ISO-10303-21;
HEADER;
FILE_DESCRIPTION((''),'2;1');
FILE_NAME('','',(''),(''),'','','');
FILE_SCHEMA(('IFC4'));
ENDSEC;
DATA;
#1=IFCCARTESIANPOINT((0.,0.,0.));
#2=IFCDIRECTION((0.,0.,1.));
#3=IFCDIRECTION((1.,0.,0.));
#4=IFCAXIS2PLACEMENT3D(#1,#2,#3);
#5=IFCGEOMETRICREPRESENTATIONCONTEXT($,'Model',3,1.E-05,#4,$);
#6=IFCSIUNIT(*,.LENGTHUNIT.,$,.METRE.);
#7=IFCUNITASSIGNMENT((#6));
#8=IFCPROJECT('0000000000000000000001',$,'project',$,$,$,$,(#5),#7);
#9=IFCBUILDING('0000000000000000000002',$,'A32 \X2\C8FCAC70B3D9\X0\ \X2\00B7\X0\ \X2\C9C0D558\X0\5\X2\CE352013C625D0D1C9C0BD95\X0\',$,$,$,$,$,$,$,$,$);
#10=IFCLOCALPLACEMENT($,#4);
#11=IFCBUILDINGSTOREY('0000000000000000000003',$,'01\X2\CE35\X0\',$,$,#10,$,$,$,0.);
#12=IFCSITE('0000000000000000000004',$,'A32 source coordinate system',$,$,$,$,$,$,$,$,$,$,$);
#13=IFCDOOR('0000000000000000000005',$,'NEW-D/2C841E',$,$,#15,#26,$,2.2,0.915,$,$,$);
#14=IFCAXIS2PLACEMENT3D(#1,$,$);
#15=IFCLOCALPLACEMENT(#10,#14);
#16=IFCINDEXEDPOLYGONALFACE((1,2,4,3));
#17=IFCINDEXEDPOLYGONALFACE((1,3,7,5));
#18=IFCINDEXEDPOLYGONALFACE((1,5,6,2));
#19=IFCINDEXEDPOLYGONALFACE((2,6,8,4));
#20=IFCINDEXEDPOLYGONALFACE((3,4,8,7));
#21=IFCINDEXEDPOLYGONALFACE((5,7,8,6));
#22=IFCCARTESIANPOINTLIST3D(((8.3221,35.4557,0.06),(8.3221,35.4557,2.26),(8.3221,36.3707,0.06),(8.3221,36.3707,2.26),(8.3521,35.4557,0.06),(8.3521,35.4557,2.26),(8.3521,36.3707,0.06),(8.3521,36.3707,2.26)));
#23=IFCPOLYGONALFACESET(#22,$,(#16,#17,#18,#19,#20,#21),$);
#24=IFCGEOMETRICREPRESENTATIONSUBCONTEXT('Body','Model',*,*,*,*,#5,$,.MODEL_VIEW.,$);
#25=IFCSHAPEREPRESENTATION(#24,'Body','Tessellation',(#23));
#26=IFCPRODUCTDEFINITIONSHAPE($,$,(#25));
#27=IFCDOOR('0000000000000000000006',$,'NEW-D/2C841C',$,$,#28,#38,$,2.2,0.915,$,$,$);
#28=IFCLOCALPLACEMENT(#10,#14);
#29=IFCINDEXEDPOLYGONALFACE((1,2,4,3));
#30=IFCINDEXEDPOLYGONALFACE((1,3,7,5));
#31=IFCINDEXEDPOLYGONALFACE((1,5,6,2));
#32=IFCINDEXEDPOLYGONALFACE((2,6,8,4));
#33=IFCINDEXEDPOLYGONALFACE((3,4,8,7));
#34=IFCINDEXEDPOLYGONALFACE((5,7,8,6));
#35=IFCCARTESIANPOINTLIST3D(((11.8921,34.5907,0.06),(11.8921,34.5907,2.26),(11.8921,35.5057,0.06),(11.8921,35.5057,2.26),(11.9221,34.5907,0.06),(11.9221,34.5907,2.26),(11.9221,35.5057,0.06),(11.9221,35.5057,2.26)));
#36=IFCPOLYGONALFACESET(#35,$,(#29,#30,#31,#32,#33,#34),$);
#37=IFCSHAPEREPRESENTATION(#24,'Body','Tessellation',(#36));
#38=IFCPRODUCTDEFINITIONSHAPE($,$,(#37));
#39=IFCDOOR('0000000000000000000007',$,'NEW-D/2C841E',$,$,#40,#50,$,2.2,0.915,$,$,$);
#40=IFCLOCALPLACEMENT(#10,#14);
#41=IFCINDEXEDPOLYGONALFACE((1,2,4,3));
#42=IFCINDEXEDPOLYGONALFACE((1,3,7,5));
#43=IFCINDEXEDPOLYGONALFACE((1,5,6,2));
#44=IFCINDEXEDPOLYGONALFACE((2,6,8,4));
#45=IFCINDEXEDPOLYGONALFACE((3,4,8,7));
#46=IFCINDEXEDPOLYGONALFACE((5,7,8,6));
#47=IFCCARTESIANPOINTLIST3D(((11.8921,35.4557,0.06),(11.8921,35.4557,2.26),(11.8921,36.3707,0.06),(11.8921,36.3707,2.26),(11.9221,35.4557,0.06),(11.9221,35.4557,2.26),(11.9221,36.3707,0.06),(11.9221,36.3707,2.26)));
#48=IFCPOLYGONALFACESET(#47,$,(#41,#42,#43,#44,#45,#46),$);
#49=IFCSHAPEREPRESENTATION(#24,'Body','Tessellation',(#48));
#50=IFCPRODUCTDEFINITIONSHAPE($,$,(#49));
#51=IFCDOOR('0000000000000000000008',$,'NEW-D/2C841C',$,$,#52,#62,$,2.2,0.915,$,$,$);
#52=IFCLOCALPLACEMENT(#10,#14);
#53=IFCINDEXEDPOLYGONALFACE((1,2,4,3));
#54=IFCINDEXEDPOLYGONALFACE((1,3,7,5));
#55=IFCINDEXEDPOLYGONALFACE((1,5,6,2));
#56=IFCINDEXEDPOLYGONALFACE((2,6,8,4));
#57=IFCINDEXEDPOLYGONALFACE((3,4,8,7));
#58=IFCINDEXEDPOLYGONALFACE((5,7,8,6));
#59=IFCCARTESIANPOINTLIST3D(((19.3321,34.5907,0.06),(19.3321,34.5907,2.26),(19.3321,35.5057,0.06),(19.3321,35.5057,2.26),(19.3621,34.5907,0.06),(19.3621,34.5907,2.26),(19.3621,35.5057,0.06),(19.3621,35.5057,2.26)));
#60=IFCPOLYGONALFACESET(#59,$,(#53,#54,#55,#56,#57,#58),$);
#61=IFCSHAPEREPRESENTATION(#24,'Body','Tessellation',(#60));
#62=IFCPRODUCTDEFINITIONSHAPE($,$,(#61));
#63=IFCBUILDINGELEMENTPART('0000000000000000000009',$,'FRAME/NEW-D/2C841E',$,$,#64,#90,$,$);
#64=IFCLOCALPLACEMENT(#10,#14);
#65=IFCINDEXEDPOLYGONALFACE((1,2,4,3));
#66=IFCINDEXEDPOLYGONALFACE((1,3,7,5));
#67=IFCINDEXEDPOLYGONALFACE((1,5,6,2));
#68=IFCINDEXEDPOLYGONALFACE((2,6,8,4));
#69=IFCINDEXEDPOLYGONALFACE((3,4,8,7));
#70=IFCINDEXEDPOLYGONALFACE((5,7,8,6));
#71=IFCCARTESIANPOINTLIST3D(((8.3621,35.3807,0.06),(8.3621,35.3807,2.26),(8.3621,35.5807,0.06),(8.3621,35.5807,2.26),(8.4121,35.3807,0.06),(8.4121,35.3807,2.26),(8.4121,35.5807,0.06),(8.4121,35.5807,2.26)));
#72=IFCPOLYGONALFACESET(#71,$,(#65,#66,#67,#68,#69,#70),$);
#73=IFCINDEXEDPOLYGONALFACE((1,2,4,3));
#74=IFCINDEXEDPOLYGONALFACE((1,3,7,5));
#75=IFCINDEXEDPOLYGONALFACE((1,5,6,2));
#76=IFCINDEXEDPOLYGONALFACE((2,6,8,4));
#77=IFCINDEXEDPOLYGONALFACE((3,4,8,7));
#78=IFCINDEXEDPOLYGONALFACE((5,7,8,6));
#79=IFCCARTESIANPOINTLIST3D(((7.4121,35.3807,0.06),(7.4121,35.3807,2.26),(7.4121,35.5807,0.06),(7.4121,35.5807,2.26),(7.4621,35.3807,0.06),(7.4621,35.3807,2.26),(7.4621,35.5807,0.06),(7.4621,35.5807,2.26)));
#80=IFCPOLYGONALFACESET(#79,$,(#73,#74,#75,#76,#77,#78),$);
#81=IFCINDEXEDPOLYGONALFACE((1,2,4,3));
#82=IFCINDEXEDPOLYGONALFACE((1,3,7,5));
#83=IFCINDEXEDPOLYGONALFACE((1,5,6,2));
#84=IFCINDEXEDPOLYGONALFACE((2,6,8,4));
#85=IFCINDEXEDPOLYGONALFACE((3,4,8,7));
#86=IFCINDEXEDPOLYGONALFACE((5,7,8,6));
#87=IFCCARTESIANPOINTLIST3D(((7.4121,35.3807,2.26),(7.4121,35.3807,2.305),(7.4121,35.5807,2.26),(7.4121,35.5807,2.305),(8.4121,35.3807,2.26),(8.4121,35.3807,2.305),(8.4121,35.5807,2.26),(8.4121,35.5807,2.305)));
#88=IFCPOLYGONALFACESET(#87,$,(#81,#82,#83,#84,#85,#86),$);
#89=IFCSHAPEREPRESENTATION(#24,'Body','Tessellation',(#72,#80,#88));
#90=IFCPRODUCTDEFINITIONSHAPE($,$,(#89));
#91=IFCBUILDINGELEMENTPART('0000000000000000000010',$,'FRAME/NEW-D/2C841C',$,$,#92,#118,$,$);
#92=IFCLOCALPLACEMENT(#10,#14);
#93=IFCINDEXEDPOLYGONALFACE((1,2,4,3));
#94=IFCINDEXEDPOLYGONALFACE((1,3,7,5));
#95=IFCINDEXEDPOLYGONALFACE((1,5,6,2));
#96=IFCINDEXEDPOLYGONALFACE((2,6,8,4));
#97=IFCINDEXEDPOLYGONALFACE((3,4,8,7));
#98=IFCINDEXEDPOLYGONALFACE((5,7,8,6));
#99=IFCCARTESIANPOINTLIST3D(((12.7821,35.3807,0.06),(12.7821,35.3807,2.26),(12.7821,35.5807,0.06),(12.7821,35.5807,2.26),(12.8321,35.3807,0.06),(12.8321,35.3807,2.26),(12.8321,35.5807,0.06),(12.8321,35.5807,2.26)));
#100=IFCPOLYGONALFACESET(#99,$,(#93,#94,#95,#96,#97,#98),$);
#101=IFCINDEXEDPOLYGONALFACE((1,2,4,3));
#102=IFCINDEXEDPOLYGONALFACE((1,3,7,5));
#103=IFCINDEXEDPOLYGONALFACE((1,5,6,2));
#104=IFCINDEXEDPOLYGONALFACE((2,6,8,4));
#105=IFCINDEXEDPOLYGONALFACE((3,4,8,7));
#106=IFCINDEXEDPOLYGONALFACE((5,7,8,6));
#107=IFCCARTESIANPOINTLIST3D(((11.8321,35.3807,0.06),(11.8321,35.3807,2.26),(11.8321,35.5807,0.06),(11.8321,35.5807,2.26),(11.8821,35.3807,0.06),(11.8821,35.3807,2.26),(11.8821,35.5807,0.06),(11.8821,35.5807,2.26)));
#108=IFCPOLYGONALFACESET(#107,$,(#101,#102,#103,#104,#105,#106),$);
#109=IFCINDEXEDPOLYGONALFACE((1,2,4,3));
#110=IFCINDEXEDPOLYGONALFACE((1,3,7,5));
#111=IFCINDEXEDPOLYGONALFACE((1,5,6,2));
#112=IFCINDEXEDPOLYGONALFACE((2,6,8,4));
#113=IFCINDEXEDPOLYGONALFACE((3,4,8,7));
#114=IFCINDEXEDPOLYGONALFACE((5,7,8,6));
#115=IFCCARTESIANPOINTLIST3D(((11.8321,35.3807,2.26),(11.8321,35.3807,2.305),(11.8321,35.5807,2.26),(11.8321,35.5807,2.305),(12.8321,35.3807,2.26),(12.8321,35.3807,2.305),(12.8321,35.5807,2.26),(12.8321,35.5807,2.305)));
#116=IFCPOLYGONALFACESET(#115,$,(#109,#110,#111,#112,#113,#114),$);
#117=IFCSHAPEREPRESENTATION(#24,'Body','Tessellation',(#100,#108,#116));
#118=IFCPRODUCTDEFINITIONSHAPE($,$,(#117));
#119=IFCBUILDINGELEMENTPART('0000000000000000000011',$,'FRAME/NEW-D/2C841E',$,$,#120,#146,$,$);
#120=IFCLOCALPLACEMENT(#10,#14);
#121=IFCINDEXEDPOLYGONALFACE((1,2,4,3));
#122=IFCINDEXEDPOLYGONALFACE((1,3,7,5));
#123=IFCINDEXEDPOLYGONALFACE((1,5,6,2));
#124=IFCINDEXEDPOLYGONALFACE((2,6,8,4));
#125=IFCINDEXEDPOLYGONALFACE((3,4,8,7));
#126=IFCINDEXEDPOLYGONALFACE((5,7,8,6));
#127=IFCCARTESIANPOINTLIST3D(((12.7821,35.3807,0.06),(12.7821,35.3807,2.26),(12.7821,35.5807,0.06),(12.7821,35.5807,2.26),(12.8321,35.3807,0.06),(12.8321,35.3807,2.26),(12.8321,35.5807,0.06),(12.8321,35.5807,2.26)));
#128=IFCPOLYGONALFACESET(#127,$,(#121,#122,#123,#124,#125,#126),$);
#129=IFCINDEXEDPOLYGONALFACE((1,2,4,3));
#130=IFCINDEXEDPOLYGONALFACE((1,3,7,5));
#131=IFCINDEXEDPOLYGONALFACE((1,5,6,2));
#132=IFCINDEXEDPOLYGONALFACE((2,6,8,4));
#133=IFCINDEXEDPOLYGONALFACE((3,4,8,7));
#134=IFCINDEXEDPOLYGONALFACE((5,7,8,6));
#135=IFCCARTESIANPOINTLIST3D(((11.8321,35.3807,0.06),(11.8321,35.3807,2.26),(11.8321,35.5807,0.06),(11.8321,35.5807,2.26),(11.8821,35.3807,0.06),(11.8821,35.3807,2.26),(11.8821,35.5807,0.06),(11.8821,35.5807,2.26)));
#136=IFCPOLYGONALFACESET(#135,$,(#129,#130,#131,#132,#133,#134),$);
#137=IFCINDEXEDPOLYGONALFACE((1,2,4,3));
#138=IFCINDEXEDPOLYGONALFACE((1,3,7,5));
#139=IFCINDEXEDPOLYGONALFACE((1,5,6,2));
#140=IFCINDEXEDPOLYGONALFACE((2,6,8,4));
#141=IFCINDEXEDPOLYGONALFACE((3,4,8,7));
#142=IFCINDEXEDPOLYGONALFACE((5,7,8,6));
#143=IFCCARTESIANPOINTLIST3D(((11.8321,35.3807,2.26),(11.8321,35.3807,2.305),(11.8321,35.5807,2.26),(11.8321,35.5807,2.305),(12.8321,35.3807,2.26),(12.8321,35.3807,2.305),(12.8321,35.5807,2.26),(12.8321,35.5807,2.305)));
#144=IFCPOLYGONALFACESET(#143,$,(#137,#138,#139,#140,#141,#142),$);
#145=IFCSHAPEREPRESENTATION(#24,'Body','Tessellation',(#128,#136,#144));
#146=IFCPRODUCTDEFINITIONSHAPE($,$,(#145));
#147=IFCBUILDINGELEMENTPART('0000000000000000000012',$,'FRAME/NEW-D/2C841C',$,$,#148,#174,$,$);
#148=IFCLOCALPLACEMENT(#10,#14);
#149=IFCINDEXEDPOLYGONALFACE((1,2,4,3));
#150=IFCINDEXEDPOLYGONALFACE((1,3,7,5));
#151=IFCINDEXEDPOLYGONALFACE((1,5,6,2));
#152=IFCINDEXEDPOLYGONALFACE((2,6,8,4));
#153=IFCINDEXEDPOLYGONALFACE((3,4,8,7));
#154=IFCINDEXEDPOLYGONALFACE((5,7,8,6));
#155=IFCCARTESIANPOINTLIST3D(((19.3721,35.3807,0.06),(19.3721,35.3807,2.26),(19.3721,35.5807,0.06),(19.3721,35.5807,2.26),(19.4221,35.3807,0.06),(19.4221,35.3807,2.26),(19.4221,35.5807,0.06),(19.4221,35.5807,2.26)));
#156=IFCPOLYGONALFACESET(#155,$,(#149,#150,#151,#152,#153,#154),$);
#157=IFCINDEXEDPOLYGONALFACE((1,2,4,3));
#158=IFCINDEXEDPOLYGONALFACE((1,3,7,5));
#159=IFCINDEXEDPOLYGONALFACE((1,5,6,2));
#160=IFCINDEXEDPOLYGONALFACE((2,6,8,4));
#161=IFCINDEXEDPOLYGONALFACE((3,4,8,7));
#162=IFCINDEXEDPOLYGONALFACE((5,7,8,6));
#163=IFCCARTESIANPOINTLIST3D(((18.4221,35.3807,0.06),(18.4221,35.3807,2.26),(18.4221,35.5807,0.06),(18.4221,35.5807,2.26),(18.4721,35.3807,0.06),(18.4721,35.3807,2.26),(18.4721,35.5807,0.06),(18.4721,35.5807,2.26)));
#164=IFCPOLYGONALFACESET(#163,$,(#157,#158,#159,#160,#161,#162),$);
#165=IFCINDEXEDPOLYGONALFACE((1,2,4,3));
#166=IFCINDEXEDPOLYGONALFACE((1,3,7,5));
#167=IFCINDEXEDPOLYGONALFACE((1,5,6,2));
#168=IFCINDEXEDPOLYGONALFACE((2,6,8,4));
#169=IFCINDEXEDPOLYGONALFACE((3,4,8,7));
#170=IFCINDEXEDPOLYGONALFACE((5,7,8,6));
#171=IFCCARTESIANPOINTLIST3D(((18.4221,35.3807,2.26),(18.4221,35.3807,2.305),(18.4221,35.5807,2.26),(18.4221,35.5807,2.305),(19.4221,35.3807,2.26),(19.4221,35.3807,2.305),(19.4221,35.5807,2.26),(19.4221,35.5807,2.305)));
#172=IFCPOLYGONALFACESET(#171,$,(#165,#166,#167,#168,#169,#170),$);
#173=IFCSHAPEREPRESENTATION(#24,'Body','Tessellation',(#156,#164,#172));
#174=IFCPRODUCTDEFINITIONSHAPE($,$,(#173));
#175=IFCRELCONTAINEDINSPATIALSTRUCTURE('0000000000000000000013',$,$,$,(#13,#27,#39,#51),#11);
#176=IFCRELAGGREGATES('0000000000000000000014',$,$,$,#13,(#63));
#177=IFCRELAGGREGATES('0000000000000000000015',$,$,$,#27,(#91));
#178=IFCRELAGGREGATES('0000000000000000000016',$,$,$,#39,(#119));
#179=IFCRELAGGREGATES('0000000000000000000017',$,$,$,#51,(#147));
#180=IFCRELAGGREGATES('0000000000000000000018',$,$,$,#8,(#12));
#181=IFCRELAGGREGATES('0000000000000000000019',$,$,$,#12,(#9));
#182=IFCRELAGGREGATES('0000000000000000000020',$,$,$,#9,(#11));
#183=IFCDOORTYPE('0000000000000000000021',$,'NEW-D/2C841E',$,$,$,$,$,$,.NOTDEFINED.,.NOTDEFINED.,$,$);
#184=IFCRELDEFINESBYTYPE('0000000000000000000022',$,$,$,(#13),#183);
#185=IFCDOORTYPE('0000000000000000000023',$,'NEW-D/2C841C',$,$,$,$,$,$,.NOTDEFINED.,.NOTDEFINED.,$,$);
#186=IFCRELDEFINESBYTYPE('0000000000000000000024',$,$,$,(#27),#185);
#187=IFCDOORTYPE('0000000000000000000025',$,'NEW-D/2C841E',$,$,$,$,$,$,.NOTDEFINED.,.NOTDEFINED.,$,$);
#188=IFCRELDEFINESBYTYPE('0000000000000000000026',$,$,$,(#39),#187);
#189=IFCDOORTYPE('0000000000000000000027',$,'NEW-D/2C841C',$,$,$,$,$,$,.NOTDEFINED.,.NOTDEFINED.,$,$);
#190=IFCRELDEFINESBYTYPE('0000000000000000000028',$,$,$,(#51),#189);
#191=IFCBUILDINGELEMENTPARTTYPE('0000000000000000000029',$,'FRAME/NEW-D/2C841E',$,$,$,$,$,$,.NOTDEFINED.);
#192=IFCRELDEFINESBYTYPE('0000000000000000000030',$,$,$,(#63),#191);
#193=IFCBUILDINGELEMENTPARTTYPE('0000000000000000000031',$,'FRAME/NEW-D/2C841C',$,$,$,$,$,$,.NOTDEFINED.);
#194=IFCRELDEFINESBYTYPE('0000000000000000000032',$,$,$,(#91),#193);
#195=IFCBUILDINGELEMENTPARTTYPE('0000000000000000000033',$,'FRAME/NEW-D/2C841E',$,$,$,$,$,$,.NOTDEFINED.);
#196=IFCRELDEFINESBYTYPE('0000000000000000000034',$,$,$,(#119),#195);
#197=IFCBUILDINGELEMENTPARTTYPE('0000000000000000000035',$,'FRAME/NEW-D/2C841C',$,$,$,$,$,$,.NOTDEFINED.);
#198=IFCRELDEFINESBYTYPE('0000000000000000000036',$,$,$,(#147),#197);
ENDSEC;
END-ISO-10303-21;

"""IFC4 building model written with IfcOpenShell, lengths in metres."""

from ifc_helpers import new_model, si_unit, frame, origin, origin_with_axes, place, context, subcontext, project, spatial, polyline, outline, extrude, source, transform, mapped, type_object, type_shapes, element, aggregate, save


model = new_model("IFC4")

# Units and contexts
model_context = context("Model", 3, precision=1e-05, world=origin_with_axes())
body_context = subcontext(model_context, "Body", "Model", "MODEL_VIEW")
ifc_project = project(units=[si_unit("LENGTHUNIT", "METRE")], contexts=[model_context])

# Site, building, storey
site = spatial("IfcSite", under=ifc_project, Name="A32 source coordinate system")
building = spatial("IfcBuilding", under=site, Name="A32 주거동 · 지하5층–옥탑지붕")
storey_placement = place(None, origin_with_axes())
storey = spatial("IfcBuildingStorey", under=building, at=storey_placement, Name="01층", Elevation=0.0)

# Doors
door_type_1 = type_object("IfcDoorType", Name="NEW-D/2C841E", OperationType="NOTDEFINED", PredefinedType="NOTDEFINED")
shared_shape_1 = source(origin(), body_context, "Body", "SweptSolid", [
    extrude(outline(polyline([(8.3221, 35.4557), (8.3221, 36.3707), (8.3521, 36.3707), (8.3521, 35.4557), (8.3221, 35.4557)])), frame((0.0, 0.0, 0.06)), (0.0, 0.0, 1.0), 2.2),
])
type_shapes(door_type_1, [shared_shape_1])
door_1_placement = place(storey_placement, origin_with_axes())
door_1 = element("IfcDoor", 1, at=door_1_placement, inside=storey, type_object=door_type_1, Name="NEW-D/2C841E", OverallHeight=2.2, OverallWidth=0.915, context=body_context, shape_type="MappedRepresentation", body=[
    mapped(shared_shape_1, transform((0.0, 0.0, 0.0), scale=1.0)),
])
door_type_2 = type_object("IfcDoorType", Name="NEW-D/2C841C", OperationType="NOTDEFINED", PredefinedType="NOTDEFINED")
shared_shape_2 = source(origin(), body_context, "Body", "SweptSolid", [
    extrude(outline(polyline([(11.9221, 35.5057), (11.9221, 34.5907), (11.8921, 34.5907), (11.8921, 35.5057), (11.9221, 35.5057)])), frame((0.0, 0.0, 0.06)), (0.0, 0.0, 1.0), 2.2),
])
type_shapes(door_type_2, [shared_shape_2])
door_2_placement = place(storey_placement, origin_with_axes())
door_2 = element("IfcDoor", 2, at=door_2_placement, inside=storey, type_object=door_type_2, Name="NEW-D/2C841C", OverallHeight=2.2, OverallWidth=0.915, context=body_context, shape_type="MappedRepresentation", body=[
    mapped(shared_shape_2, transform((0.0, 0.0, 0.0), scale=1.0)),
])
door_type_3 = type_object("IfcDoorType", Name="NEW-D/2C841E", OperationType="NOTDEFINED", PredefinedType="NOTDEFINED")
shared_shape_3 = source(origin(), body_context, "Body", "SweptSolid", [
    extrude(outline(polyline([(11.8921, 36.3707), (11.9221, 36.3707), (11.9221, 35.4557), (11.8921, 35.4557), (11.8921, 36.3707)])), frame((0.0, 0.0, 0.06)), (0.0, 0.0, 1.0), 2.2),
])
type_shapes(door_type_3, [shared_shape_3])
door_3_placement = place(storey_placement, origin_with_axes())
door_3 = element("IfcDoor", 3, at=door_3_placement, inside=storey, type_object=door_type_3, Name="NEW-D/2C841E", OverallHeight=2.2, OverallWidth=0.915, context=body_context, shape_type="MappedRepresentation", body=[
    mapped(shared_shape_3, transform((0.0, 0.0, 0.0), scale=1.0)),
])
door_type_4 = type_object("IfcDoorType", Name="NEW-D/2C841C", OperationType="NOTDEFINED", PredefinedType="NOTDEFINED")
shared_shape_4 = source(origin(), body_context, "Body", "SweptSolid", [
    extrude(outline(polyline([(19.3621, 34.5907), (19.3321, 34.5907), (19.3321, 35.5057), (19.3621, 35.5057), (19.3621, 34.5907)])), frame((0.0, 0.0, 0.06)), (0.0, 0.0, 1.0), 2.2),
])
type_shapes(door_type_4, [shared_shape_4])
door_4_placement = place(storey_placement, origin_with_axes())
door_4 = element("IfcDoor", 4, at=door_4_placement, inside=storey, type_object=door_type_4, Name="NEW-D/2C841C", OverallHeight=2.2, OverallWidth=0.915, context=body_context, shape_type="MappedRepresentation", body=[
    mapped(shared_shape_4, transform((0.0, 0.0, 0.0), scale=1.0)),
])

# Building element parts
building_element_part_type_1 = type_object("IfcBuildingElementPartType", Name="FRAME/NEW-D/2C841E", PredefinedType="NOTDEFINED")
shared_shape_5 = source(origin(), body_context, "Body", "SweptSolid", [
    extrude(outline(polyline([(8.3621, 35.5807), (8.4121, 35.5807), (8.4121, 35.3807), (8.3621, 35.3807), (8.3621, 35.5807)])), frame((0.0, 0.0, 0.06)), (0.0, 0.0, 1.0), 2.2),
    extrude(outline(polyline([(7.4121, 35.5807), (7.4621, 35.5807), (7.4621, 35.3807), (7.4121, 35.3807), (7.4121, 35.5807)])), frame((0.0, 0.0, 0.06)), (0.0, 0.0, 1.0), 2.2),
    extrude(outline(polyline([(8.4121, 35.3807), (8.4121, 35.5807), (7.4121, 35.5807), (7.4121, 35.3807), (8.4121, 35.3807)])), frame((0.0, 0.0, 2.26)), (0.0, 0.0, 1.0), 0.045),
])
type_shapes(building_element_part_type_1, [shared_shape_5])
building_element_part_1_placement = place(door_1_placement, origin_with_axes())
building_element_part_1 = element("IfcBuildingElementPart", 5, at=building_element_part_1_placement, type_object=building_element_part_type_1, Name="FRAME/NEW-D/2C841E", context=body_context, shape_type="MappedRepresentation", body=[
    mapped(shared_shape_5, transform((0.0, 0.0, 0.0), scale=1.0)),
])
aggregate(door_1, [building_element_part_1])
building_element_part_type_2 = type_object("IfcBuildingElementPartType", Name="FRAME/NEW-D/2C841C", PredefinedType="NOTDEFINED")
shared_shape_6 = source(origin(), body_context, "Body", "SweptSolid", [
    extrude(outline(polyline([(12.8321, 35.5807), (12.8321, 35.3807), (12.7821, 35.3807), (12.7821, 35.5807), (12.8321, 35.5807)])), frame((0.0, 0.0, 0.06)), (0.0, 0.0, 1.0), 2.2),
    extrude(outline(polyline([(11.8821, 35.5807), (11.8821, 35.3807), (11.8321, 35.3807), (11.8321, 35.5807), (11.8821, 35.5807)])), frame((0.0, 0.0, 0.06)), (0.0, 0.0, 1.0), 2.2),
    extrude(outline(polyline([(12.8321, 35.3807), (12.8321, 35.5807), (11.8321, 35.5807), (11.8321, 35.3807), (12.8321, 35.3807)])), frame((0.0, 0.0, 2.26)), (0.0, 0.0, 1.0), 0.045),
])
type_shapes(building_element_part_type_2, [shared_shape_6])
building_element_part_2_placement = place(door_2_placement, origin_with_axes())
building_element_part_2 = element("IfcBuildingElementPart", 6, at=building_element_part_2_placement, type_object=building_element_part_type_2, Name="FRAME/NEW-D/2C841C", context=body_context, shape_type="MappedRepresentation", body=[
    mapped(shared_shape_6, transform((0.0, 0.0, 0.0), scale=1.0)),
])
aggregate(door_2, [building_element_part_2])
building_element_part_type_3 = type_object("IfcBuildingElementPartType", Name="FRAME/NEW-D/2C841E", PredefinedType="NOTDEFINED")
shared_shape_7 = source(origin(), body_context, "Body", "SweptSolid", [
    extrude(outline(polyline([(12.8321, 35.5807), (12.8321, 35.3807), (12.7821, 35.3807), (12.7821, 35.5807), (12.8321, 35.5807)])), frame((0.0, 0.0, 0.06)), (0.0, 0.0, 1.0), 2.2),
    extrude(outline(polyline([(11.8821, 35.5807), (11.8821, 35.3807), (11.8321, 35.3807), (11.8321, 35.5807), (11.8821, 35.5807)])), frame((0.0, 0.0, 0.06)), (0.0, 0.0, 1.0), 2.2),
    extrude(outline(polyline([(12.8321, 35.3807), (12.8321, 35.5807), (11.8321, 35.5807), (11.8321, 35.3807), (12.8321, 35.3807)])), frame((0.0, 0.0, 2.26)), (0.0, 0.0, 1.0), 0.045),
])
type_shapes(building_element_part_type_3, [shared_shape_7])
building_element_part_3_placement = place(door_3_placement, origin_with_axes())
building_element_part_3 = element("IfcBuildingElementPart", 7, at=building_element_part_3_placement, type_object=building_element_part_type_3, Name="FRAME/NEW-D/2C841E", context=body_context, shape_type="MappedRepresentation", body=[
    mapped(shared_shape_7, transform((0.0, 0.0, 0.0), scale=1.0)),
])
aggregate(door_3, [building_element_part_3])
building_element_part_type_4 = type_object("IfcBuildingElementPartType", Name="FRAME/NEW-D/2C841C", PredefinedType="NOTDEFINED")
shared_shape_8 = source(origin(), body_context, "Body", "SweptSolid", [
    extrude(outline(polyline([(19.3721, 35.5807), (19.4221, 35.5807), (19.4221, 35.3807), (19.3721, 35.3807), (19.3721, 35.5807)])), frame((0.0, 0.0, 0.06)), (0.0, 0.0, 1.0), 2.2),
    extrude(outline(polyline([(18.4221, 35.5807), (18.4721, 35.5807), (18.4721, 35.3807), (18.4221, 35.3807), (18.4221, 35.5807)])), frame((0.0, 0.0, 0.06)), (0.0, 0.0, 1.0), 2.2),
    extrude(outline(polyline([(19.4221, 35.3807), (19.4221, 35.5807), (18.4221, 35.5807), (18.4221, 35.3807), (19.4221, 35.3807)])), frame((0.0, 0.0, 2.26)), (0.0, 0.0, 1.0), 0.045),
])
type_shapes(building_element_part_type_4, [shared_shape_8])
building_element_part_4_placement = place(door_4_placement, origin_with_axes())
building_element_part_4 = element("IfcBuildingElementPart", 8, at=building_element_part_4_placement, type_object=building_element_part_type_4, Name="FRAME/NEW-D/2C841C", context=body_context, shape_type="MappedRepresentation", body=[
    mapped(shared_shape_8, transform((0.0, 0.0, 0.0), scale=1.0)),
])
aggregate(door_4, [building_element_part_4])

save(model, "model.ifc")
